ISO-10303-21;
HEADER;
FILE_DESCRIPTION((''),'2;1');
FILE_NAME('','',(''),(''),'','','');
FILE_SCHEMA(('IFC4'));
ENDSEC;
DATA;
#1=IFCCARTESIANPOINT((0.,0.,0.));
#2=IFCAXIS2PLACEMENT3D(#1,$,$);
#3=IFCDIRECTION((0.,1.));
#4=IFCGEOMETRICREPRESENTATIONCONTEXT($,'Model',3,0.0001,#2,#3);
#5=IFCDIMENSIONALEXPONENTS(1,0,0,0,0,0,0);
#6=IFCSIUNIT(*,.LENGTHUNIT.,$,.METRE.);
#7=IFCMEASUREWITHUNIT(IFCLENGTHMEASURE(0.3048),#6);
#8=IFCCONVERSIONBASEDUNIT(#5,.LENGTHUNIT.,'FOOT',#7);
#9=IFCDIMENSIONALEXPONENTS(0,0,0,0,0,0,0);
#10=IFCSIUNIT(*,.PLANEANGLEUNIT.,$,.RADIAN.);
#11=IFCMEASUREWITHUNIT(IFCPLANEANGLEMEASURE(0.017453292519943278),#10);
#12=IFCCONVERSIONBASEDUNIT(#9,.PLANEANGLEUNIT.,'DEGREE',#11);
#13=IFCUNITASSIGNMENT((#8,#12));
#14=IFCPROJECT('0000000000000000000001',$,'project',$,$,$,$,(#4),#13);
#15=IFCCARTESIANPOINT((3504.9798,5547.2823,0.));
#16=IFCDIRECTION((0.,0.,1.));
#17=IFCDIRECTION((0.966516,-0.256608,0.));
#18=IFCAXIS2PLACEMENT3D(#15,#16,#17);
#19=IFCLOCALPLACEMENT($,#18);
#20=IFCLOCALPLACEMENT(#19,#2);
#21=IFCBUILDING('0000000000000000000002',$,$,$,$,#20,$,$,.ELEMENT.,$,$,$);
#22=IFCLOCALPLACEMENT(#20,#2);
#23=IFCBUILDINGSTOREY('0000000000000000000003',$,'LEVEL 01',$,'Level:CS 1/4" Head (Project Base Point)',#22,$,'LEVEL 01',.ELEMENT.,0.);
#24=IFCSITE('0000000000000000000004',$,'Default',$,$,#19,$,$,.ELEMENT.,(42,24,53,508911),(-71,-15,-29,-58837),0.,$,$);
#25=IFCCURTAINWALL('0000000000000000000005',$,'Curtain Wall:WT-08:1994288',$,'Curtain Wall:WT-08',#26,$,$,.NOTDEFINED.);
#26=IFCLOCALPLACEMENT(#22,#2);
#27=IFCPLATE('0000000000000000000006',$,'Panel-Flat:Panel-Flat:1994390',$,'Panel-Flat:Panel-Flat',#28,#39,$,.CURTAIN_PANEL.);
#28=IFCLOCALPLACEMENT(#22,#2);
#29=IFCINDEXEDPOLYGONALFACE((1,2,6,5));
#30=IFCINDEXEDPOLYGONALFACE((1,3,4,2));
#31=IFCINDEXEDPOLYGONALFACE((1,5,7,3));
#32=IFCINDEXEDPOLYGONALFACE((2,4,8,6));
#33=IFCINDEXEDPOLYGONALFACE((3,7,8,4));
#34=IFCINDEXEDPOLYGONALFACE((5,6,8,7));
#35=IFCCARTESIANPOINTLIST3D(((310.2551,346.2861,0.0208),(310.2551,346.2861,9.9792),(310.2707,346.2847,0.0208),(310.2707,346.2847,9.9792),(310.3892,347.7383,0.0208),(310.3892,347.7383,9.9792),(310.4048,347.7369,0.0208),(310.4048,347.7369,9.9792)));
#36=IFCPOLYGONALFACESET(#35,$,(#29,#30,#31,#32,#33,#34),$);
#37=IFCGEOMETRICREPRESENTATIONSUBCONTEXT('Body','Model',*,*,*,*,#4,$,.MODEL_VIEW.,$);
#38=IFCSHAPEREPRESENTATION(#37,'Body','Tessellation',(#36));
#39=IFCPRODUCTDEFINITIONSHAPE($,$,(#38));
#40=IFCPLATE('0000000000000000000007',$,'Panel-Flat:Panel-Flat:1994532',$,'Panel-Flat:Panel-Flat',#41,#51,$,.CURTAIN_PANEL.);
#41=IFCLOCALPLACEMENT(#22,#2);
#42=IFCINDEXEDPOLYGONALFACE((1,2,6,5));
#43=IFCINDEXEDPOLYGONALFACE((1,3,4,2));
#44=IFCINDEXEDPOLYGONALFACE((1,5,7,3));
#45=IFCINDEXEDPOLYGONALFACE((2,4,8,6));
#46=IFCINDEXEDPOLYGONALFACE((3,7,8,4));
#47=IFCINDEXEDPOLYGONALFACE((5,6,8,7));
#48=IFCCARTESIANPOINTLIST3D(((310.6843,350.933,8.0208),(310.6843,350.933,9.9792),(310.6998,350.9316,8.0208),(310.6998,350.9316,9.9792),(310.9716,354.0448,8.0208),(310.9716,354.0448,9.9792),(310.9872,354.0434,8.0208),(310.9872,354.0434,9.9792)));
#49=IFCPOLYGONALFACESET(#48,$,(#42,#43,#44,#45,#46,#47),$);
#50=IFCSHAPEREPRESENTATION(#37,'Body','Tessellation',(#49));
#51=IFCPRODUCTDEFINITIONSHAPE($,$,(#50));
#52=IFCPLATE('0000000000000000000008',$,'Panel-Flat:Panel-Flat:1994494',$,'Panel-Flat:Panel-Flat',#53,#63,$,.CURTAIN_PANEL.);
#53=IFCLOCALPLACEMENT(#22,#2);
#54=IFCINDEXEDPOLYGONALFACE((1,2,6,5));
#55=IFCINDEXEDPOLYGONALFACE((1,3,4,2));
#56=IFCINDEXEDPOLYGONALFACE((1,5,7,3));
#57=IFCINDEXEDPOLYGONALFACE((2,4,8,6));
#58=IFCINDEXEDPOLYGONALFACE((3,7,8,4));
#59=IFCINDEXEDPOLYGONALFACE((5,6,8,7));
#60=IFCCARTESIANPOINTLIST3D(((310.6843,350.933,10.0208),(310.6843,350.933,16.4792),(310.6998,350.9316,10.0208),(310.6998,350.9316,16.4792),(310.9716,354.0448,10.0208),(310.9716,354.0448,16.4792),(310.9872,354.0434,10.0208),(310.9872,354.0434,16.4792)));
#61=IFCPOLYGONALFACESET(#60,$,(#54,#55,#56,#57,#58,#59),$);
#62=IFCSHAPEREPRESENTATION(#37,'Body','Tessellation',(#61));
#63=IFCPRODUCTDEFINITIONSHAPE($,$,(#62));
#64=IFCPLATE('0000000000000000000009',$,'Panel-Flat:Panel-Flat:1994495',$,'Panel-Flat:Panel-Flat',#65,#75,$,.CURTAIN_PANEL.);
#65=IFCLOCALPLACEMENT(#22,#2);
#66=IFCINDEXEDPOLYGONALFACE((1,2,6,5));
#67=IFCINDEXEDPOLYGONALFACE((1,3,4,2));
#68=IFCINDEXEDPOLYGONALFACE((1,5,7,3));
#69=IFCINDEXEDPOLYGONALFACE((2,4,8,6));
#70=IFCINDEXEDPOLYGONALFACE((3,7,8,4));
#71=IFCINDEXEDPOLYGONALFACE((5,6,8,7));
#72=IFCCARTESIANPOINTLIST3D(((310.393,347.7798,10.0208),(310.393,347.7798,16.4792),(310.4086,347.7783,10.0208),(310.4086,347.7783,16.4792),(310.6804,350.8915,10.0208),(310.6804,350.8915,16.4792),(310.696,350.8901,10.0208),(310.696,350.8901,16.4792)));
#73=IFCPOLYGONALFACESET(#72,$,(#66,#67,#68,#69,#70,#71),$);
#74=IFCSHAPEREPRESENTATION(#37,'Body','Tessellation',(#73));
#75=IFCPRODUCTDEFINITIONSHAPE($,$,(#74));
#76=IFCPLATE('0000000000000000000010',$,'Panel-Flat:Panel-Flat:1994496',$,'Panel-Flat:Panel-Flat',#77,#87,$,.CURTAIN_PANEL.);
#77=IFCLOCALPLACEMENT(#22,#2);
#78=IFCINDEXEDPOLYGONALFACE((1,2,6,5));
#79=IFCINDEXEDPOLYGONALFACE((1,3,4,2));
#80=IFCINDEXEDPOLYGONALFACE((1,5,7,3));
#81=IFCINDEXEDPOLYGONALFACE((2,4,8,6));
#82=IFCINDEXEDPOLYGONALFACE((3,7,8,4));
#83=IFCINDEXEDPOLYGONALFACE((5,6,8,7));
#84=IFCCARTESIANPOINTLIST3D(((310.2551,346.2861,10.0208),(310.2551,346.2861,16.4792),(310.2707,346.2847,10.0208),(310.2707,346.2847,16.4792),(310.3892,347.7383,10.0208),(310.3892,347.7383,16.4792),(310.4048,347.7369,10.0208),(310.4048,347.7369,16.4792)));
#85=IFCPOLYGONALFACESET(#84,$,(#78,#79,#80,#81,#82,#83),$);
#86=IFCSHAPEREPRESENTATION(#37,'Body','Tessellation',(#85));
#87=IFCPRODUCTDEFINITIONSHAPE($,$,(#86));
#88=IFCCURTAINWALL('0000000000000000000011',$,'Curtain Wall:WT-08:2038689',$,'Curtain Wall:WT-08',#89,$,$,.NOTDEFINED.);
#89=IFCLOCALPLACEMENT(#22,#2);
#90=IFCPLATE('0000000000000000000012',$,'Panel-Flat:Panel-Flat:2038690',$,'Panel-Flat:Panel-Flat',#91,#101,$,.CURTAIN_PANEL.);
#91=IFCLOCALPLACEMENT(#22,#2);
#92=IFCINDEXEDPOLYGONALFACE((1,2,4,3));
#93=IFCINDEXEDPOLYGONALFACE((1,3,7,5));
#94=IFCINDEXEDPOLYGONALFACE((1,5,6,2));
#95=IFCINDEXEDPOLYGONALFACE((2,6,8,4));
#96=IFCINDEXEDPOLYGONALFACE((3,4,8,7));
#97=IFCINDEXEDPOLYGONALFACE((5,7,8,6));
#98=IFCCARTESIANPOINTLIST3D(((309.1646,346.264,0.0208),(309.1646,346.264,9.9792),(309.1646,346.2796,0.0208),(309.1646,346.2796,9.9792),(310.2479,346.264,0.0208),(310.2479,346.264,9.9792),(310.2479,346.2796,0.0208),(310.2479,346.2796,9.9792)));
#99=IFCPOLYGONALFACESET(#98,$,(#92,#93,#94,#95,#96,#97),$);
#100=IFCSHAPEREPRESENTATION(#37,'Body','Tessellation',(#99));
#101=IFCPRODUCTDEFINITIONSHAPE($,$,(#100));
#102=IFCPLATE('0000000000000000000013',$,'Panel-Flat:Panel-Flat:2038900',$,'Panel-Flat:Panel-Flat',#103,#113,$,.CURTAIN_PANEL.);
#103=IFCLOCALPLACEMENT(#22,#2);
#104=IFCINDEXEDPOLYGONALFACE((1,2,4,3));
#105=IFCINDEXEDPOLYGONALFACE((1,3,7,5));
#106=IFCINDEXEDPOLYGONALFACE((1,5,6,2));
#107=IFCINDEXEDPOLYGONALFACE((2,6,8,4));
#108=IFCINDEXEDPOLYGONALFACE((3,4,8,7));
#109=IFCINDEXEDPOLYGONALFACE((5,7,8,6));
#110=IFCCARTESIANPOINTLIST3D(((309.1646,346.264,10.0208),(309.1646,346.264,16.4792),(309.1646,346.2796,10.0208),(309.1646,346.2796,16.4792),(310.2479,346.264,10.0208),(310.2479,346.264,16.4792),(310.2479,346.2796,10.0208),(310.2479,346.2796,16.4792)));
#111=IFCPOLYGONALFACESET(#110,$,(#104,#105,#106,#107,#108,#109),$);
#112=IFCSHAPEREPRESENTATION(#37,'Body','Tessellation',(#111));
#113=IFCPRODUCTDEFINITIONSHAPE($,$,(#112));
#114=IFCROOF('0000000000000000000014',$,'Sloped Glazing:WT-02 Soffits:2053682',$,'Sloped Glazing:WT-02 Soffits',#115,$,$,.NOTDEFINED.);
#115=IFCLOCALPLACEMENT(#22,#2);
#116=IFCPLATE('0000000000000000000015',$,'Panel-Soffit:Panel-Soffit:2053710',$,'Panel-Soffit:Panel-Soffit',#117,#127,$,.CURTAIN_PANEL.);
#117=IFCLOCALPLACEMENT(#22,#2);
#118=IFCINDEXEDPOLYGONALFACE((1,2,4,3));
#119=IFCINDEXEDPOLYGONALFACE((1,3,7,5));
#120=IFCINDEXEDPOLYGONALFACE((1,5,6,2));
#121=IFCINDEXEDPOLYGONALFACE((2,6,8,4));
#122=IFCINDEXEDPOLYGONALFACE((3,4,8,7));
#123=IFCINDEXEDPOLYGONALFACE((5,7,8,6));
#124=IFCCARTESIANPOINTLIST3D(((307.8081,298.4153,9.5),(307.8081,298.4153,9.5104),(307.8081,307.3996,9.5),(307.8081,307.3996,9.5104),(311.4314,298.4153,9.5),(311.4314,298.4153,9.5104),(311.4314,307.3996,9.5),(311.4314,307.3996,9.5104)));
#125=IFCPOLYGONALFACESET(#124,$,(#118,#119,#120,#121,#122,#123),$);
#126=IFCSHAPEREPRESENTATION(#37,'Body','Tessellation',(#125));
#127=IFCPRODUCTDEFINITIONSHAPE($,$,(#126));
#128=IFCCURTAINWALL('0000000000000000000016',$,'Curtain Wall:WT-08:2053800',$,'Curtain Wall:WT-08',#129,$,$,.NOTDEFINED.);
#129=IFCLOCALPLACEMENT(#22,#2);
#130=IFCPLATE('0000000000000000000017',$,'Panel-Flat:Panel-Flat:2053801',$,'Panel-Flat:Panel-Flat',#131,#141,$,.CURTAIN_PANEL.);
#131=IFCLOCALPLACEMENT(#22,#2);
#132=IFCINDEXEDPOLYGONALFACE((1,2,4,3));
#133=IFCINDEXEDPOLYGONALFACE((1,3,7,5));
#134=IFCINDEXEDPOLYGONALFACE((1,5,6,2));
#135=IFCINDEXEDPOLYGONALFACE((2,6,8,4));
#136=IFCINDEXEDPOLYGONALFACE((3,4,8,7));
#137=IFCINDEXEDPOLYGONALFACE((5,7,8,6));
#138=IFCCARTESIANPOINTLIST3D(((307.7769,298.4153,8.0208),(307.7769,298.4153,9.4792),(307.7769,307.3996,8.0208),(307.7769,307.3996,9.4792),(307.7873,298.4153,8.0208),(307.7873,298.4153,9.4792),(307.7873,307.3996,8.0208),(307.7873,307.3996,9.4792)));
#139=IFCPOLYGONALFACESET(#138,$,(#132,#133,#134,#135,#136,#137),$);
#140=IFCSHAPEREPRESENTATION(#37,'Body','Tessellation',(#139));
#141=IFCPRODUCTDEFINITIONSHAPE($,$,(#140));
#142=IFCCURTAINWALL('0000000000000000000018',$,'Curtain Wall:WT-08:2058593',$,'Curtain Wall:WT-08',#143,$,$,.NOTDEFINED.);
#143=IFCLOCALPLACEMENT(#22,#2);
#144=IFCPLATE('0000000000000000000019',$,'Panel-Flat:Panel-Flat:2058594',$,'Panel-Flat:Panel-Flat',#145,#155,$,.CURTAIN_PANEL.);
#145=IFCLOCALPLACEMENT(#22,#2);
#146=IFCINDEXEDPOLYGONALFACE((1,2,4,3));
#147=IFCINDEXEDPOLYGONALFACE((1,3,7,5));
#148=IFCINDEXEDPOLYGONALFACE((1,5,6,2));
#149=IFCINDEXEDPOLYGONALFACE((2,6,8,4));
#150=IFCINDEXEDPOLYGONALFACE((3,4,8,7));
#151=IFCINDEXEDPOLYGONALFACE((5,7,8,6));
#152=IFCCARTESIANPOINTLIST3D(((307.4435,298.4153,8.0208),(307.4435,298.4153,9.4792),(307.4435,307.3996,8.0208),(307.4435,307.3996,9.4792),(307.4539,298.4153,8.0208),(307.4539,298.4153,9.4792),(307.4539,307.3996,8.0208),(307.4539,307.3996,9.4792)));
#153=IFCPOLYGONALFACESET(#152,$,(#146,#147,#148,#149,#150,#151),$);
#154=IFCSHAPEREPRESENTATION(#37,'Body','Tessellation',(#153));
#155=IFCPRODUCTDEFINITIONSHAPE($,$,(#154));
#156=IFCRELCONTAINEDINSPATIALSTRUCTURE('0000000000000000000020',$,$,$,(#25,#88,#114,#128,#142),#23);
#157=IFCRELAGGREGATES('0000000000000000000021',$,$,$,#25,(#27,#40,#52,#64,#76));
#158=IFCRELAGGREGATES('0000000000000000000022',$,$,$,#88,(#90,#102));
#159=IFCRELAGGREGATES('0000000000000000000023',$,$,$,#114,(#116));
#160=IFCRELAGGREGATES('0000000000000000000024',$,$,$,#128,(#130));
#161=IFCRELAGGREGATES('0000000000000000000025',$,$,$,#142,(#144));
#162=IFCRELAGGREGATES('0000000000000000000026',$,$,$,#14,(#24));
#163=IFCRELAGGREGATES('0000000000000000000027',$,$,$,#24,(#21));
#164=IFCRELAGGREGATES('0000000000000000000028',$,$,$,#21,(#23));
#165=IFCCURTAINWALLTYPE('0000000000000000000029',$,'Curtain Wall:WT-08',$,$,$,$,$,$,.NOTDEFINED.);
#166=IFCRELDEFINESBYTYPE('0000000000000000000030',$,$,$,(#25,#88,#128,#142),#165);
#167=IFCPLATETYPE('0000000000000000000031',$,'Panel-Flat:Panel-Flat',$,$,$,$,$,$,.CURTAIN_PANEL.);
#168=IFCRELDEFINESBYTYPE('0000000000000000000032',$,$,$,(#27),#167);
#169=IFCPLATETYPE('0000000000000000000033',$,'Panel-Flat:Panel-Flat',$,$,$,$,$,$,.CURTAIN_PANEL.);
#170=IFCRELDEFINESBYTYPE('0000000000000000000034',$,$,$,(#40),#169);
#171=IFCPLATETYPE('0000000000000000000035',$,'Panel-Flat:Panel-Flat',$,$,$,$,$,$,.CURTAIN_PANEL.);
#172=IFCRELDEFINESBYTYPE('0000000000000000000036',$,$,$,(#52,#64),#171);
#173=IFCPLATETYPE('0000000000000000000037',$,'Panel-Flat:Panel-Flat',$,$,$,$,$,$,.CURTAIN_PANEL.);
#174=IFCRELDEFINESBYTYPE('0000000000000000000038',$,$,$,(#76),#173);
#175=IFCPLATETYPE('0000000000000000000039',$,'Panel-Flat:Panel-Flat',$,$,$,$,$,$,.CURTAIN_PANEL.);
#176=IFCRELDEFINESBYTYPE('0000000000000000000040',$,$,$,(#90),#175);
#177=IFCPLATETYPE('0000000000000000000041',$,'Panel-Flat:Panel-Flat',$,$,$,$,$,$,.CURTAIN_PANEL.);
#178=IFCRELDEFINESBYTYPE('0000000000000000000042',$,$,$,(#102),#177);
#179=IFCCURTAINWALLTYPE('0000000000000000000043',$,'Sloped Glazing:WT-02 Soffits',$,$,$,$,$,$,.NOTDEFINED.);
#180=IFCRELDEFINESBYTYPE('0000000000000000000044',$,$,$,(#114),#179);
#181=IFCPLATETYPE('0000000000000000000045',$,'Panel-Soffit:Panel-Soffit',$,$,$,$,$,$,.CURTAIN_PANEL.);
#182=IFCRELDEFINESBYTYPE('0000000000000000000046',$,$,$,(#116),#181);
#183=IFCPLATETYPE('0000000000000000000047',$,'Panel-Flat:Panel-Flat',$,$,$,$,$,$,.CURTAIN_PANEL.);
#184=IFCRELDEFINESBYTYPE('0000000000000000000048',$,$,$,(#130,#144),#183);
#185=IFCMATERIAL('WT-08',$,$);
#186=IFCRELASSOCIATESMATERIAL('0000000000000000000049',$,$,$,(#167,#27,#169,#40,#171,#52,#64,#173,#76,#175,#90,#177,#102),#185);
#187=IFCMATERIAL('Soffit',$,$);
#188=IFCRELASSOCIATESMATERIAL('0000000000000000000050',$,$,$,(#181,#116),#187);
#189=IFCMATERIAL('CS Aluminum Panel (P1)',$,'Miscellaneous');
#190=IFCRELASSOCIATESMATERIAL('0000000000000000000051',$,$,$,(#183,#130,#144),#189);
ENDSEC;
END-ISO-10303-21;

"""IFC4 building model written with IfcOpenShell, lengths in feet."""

from ifc_helpers import new_model, entity, si_unit, converted_unit, direction, frame, origin, place, context, subcontext, project, spatial, indexed_curve, outline, extrude, source, transform, mapped, material, type_object, type_shapes, element, aggregate, save


model = new_model("IFC4")

# Units and contexts
model_context = context("Model", 3, precision=0.0001, world=origin(), true_north=direction((0.0, 1.0)))
body_context = subcontext(model_context, "Body", "Model", "MODEL_VIEW")
ifc_project = project(units=[converted_unit("LENGTHUNIT", "FOOT", entity("IfcLengthMeasure", 0.3048), si_unit("LENGTHUNIT", "METRE"), dimensions=[1, 0, 0, 0, 0, 0, 0]), converted_unit("PLANEANGLEUNIT", "DEGREE", entity("IfcPlaneAngleMeasure", 0.017453292519943278), si_unit("PLANEANGLEUNIT", "RADIAN"), dimensions=[0, 0, 0, 0, 0, 0, 0])], contexts=[model_context])

# Site, building, storey
site_placement = place(None, frame((3504.9798, 5547.2823, 0.0), z_axis=(0.0, 0.0, 1.0), x_axis=(0.966516, -0.256608, 0.0)))
site = spatial("IfcSite", under=ifc_project, at=site_placement, Name="Default", CompositionType="ELEMENT", RefLatitude=(42, 24, 53, 508911), RefLongitude=(-71, -15, -29, -58837), RefElevation=0.0)
building_placement = place(site_placement, origin())
building = spatial("IfcBuilding", under=site, at=building_placement, CompositionType="ELEMENT")
storey_placement = place(building_placement, origin())
storey = spatial("IfcBuildingStorey", under=building, at=storey_placement, Name="LEVEL 01", ObjectType="Level:CS 1/4\" Head (Project Base Point)", LongName="LEVEL 01", CompositionType="ELEMENT", Elevation=0.0)

# Shared definitions
curtain_wall_type_1 = type_object("IfcCurtainWallType", Name="Curtain Wall:WT-08", PredefinedType="NOTDEFINED")
ifc_material_1 = material(Name="WT-08")

# Curtain wall
curtain_wall_1_placement = place(storey_placement, origin())
curtain_wall_1 = element("IfcCurtainWall", 1, at=curtain_wall_1_placement, inside=storey, type_object=curtain_wall_type_1, Name="Curtain Wall:WT-08:1994288", ObjectType="Curtain Wall:WT-08", PredefinedType="NOTDEFINED")

# Plates
plate_type_1 = type_object("IfcPlateType", Name="Panel-Flat:Panel-Flat", PredefinedType="CURTAIN_PANEL", material=ifc_material_1)
shared_shape_1 = source(origin(), body_context, "Body", "SweptSolid", [
    extrude(outline(indexed_curve([(-0.0078, -0.7292), (0.0078, -0.7292), (0.0078, 0.7292), (-0.0078, 0.7292), (-0.0078, -0.7292)], self_intersect=False)), frame((0.0, -0.0078, 0.0208), z_axis=(0.0, 0.0, 1.0), x_axis=(0.0, -1.0, 0.0)), (0.0, 0.0, 1.0), 9.9583),
])
type_shapes(plate_type_1, [shared_shape_1])
plate_1_placement = place(curtain_wall_1_placement, frame((310.3377, 347.0108, 0.0), z_axis=(0.0, 0.0, 1.0), x_axis=(-0.091962, -0.995763, 0.0)))
plate_1 = element("IfcPlate", 2, at=plate_1_placement, type_object=plate_type_1, material=ifc_material_1, Name="Panel-Flat:Panel-Flat:1994390", ObjectType="Panel-Flat:Panel-Flat", PredefinedType="CURTAIN_PANEL", context=body_context, shape_type="MappedRepresentation", body=[
    mapped(shared_shape_1, transform((0.0, 0.0, 0.0), scale=1.0)),
])
plate_type_2 = type_object("IfcPlateType", Name="Panel-Flat:Panel-Flat", PredefinedType="CURTAIN_PANEL", material=ifc_material_1)
shared_shape_2 = source(origin(), body_context, "Body", "SweptSolid", [
    extrude(outline(indexed_curve([(-0.0078, -1.5625), (0.0078, -1.5625), (0.0078, 1.5625), (-0.0078, 1.5625), (-0.0078, -1.5625)], self_intersect=False)), frame((0.0, -0.0078, 0.0208), z_axis=(0.0, 0.0, 1.0), x_axis=(0.0, -1.0, 0.0)), (0.0, 0.0, 1.0), 1.9583),
])
type_shapes(plate_type_2, [shared_shape_2])
plate_2_placement = place(curtain_wall_1_placement, frame((310.8435, 352.4875, 8.0), z_axis=(0.0, 0.0, 1.0), x_axis=(-0.091962, -0.995763, 0.0)))
plate_2 = element("IfcPlate", 3, at=plate_2_placement, type_object=plate_type_2, material=ifc_material_1, Name="Panel-Flat:Panel-Flat:1994532", ObjectType="Panel-Flat:Panel-Flat", PredefinedType="CURTAIN_PANEL", context=body_context, shape_type="MappedRepresentation", body=[
    mapped(shared_shape_2, transform((0.0, 0.0, 0.0), scale=1.0)),
])
plate_type_3 = type_object("IfcPlateType", Name="Panel-Flat:Panel-Flat", PredefinedType="CURTAIN_PANEL", material=ifc_material_1)
shared_shape_3 = source(origin(), body_context, "Body", "SweptSolid", [
    extrude(outline(indexed_curve([(-0.0078, -1.5625), (0.0078, -1.5625), (0.0078, 1.5625), (-0.0078, 1.5625), (-0.0078, -1.5625)], self_intersect=False)), frame((0.0, -0.0078, 0.0208), z_axis=(0.0, 0.0, 1.0), x_axis=(0.0, -1.0, 0.0)), (0.0, 0.0, 1.0), 6.4583),
])
type_shapes(plate_type_3, [shared_shape_3])
plate_3_placement = place(curtain_wall_1_placement, frame((310.8435, 352.4875, 10.0), z_axis=(0.0, 0.0, 1.0), x_axis=(-0.091962, -0.995763, 0.0)))
plate_3 = element("IfcPlate", 4, at=plate_3_placement, type_object=plate_type_3, material=ifc_material_1, Name="Panel-Flat:Panel-Flat:1994494", ObjectType="Panel-Flat:Panel-Flat", PredefinedType="CURTAIN_PANEL", context=body_context, shape_type="MappedRepresentation", body=[
    mapped(shared_shape_3, transform((0.0, 0.0, 0.0), scale=1.0)),
])
plate_4_placement = place(curtain_wall_1_placement, frame((310.5523, 349.3342, 10.0), z_axis=(0.0, 0.0, 1.0), x_axis=(-0.091962, -0.995763, 0.0)))
plate_4 = element("IfcPlate", 5, at=plate_4_placement, type_object=plate_type_3, material=ifc_material_1, Name="Panel-Flat:Panel-Flat:1994495", ObjectType="Panel-Flat:Panel-Flat", PredefinedType="CURTAIN_PANEL", context=body_context, shape_type="MappedRepresentation", body=[
    mapped(shared_shape_3, transform((0.0, 0.0, 0.0), scale=1.0)),
])
plate_type_4 = type_object("IfcPlateType", Name="Panel-Flat:Panel-Flat", PredefinedType="CURTAIN_PANEL", material=ifc_material_1)
shared_shape_4 = source(origin(), body_context, "Body", "SweptSolid", [
    extrude(outline(indexed_curve([(-0.0078, -0.7292), (0.0078, -0.7292), (0.0078, 0.7292), (-0.0078, 0.7292), (-0.0078, -0.7292)], self_intersect=False)), frame((0.0, -0.0078, 0.0208), z_axis=(0.0, 0.0, 1.0), x_axis=(0.0, -1.0, 0.0)), (0.0, 0.0, 1.0), 6.4583),
])
type_shapes(plate_type_4, [shared_shape_4])
plate_5_placement = place(curtain_wall_1_placement, frame((310.3377, 347.0108, 10.0), z_axis=(0.0, 0.0, 1.0), x_axis=(-0.091962, -0.995763, 0.0)))
plate_5 = element("IfcPlate", 6, at=plate_5_placement, type_object=plate_type_4, material=ifc_material_1, Name="Panel-Flat:Panel-Flat:1994496", ObjectType="Panel-Flat:Panel-Flat", PredefinedType="CURTAIN_PANEL", context=body_context, shape_type="MappedRepresentation", body=[
    mapped(shared_shape_4, transform((0.0, 0.0, 0.0), scale=1.0)),
])
aggregate(curtain_wall_1, [plate_1, plate_2, plate_3, plate_4, plate_5])

# Curtain wall, plates
curtain_wall_2_placement = place(storey_placement, origin())
curtain_wall_2 = element("IfcCurtainWall", 7, at=curtain_wall_2_placement, inside=storey, type_object=curtain_wall_type_1, Name="Curtain Wall:WT-08:2038689", ObjectType="Curtain Wall:WT-08", PredefinedType="NOTDEFINED")
plate_type_5 = type_object("IfcPlateType", Name="Panel-Flat:Panel-Flat", PredefinedType="CURTAIN_PANEL", material=ifc_material_1)
shared_shape_5 = source(origin(), body_context, "Body", "SweptSolid", [
    extrude(outline(indexed_curve([(-0.0078, -0.5417), (0.0078, -0.5417), (0.0078, 0.5417), (-0.0078, 0.5417), (-0.0078, -0.5417)], self_intersect=False)), frame((0.0, -0.0078, 0.0208), z_axis=(0.0, 0.0, 1.0), x_axis=(0.0, -1.0, 0.0)), (0.0, 0.0, 1.0), 9.9583),
])
type_shapes(plate_type_5, [shared_shape_5])
plate_6_placement = place(curtain_wall_2_placement, frame((309.7062, 346.264, 0.0), z_axis=(0.0, 0.0, 1.0), x_axis=(-1.0, 0.0, 0.0)))
plate_6 = element("IfcPlate", 8, at=plate_6_placement, type_object=plate_type_5, material=ifc_material_1, Name="Panel-Flat:Panel-Flat:2038690", ObjectType="Panel-Flat:Panel-Flat", PredefinedType="CURTAIN_PANEL", context=body_context, shape_type="MappedRepresentation", body=[
    mapped(shared_shape_5, transform((0.0, 0.0, 0.0), scale=1.0)),
])
plate_type_6 = type_object("IfcPlateType", Name="Panel-Flat:Panel-Flat", PredefinedType="CURTAIN_PANEL", material=ifc_material_1)
shared_shape_6 = source(origin(), body_context, "Body", "SweptSolid", [
    extrude(outline(indexed_curve([(-0.0078, -0.5417), (0.0078, -0.5417), (0.0078, 0.5417), (-0.0078, 0.5417), (-0.0078, -0.5417)], self_intersect=False)), frame((0.0, -0.0078, 0.0208), z_axis=(0.0, 0.0, 1.0), x_axis=(0.0, -1.0, 0.0)), (0.0, 0.0, 1.0), 6.4583),
])
type_shapes(plate_type_6, [shared_shape_6])
plate_7_placement = place(curtain_wall_2_placement, frame((309.7062, 346.264, 10.0), z_axis=(0.0, 0.0, 1.0), x_axis=(-1.0, 0.0, 0.0)))
plate_7 = element("IfcPlate", 9, at=plate_7_placement, type_object=plate_type_6, material=ifc_material_1, Name="Panel-Flat:Panel-Flat:2038900", ObjectType="Panel-Flat:Panel-Flat", PredefinedType="CURTAIN_PANEL", context=body_context, shape_type="MappedRepresentation", body=[
    mapped(shared_shape_6, transform((0.0, 0.0, 0.0), scale=1.0)),
])
aggregate(curtain_wall_2, [plate_6, plate_7])

# Roof, plate
curtain_wall_type_2 = type_object("IfcCurtainWallType", Name="Sloped Glazing:WT-02 Soffits", PredefinedType="NOTDEFINED")
roof_placement = place(storey_placement, origin())
roof = element("IfcRoof", 10, at=roof_placement, inside=storey, type_object=curtain_wall_type_2, Name="Sloped Glazing:WT-02 Soffits:2053682", ObjectType="Sloped Glazing:WT-02 Soffits", PredefinedType="NOTDEFINED")
ifc_material_2 = material(Name="Soffit")
plate_type_7 = type_object("IfcPlateType", Name="Panel-Soffit:Panel-Soffit", PredefinedType="CURTAIN_PANEL", material=ifc_material_2)
shared_shape_7 = source(origin(), body_context, "Body", "SweptSolid", [
    extrude(outline(indexed_curve([(-0.0052, -1.8117), (0.0052, -1.8117), (0.0052, 1.8117), (-0.0052, 1.8117), (-0.0052, -1.8117)], self_intersect=False)), frame((0.0, -0.0052, 0.0208), z_axis=(0.0, 0.0, 1.0), x_axis=(0.0, -1.0, 0.0)), (0.0, 0.0, 1.0), 8.9844),
])
type_shapes(plate_type_7, [shared_shape_7])
plate_8_placement = place(roof_placement, frame((309.6198, 298.3944, 9.5), z_axis=(0.0, 1.0, 0.0), x_axis=(1.0, 0.0, 0.0)))
plate_8 = element("IfcPlate", 11, at=plate_8_placement, type_object=plate_type_7, material=ifc_material_2, Name="Panel-Soffit:Panel-Soffit:2053710", ObjectType="Panel-Soffit:Panel-Soffit", PredefinedType="CURTAIN_PANEL", context=body_context, shape_type="MappedRepresentation", body=[
    mapped(shared_shape_7, transform((0.0, 0.0, 0.0), scale=1.0)),
])
aggregate(roof, [plate_8])

# Curtain walls, plates
curtain_wall_3_placement = place(storey_placement, origin())
curtain_wall_3 = element("IfcCurtainWall", 12, at=curtain_wall_3_placement, inside=storey, type_object=curtain_wall_type_1, Name="Curtain Wall:WT-08:2053800", ObjectType="Curtain Wall:WT-08", PredefinedType="NOTDEFINED")
ifc_material_3 = material(Name="CS Aluminum Panel (P1)", Category="Miscellaneous")
plate_type_8 = type_object("IfcPlateType", Name="Panel-Flat:Panel-Flat", PredefinedType="CURTAIN_PANEL", material=ifc_material_3)
shared_shape_8 = source(origin(), body_context, "Body", "SweptSolid", [
    extrude(outline(indexed_curve([(-0.0052, -4.4922), (0.0052, -4.4922), (0.0052, 4.4922), (-0.0052, 4.4922), (-0.0052, -4.4922)], self_intersect=False)), frame((0.0, -0.0052, 0.0208), z_axis=(0.0, 0.0, 1.0), x_axis=(0.0, -1.0, 0.0)), (0.0, 0.0, 1.0), 1.4583),
])
type_shapes(plate_type_8, [shared_shape_8])
plate_9_placement = place(curtain_wall_3_placement, frame((307.7873, 302.9075, 8.0), z_axis=(0.0, 0.0, 1.0), x_axis=(0.0, -1.0, 0.0)))
plate_9 = element("IfcPlate", 13, at=plate_9_placement, type_object=plate_type_8, material=ifc_material_3, Name="Panel-Flat:Panel-Flat:2053801", ObjectType="Panel-Flat:Panel-Flat", PredefinedType="CURTAIN_PANEL", context=body_context, shape_type="MappedRepresentation", body=[
    mapped(shared_shape_8, transform((0.0, 0.0, 0.0), scale=1.0)),
])
aggregate(curtain_wall_3, [plate_9])
curtain_wall_4_placement = place(storey_placement, origin())
curtain_wall_4 = element("IfcCurtainWall", 14, at=curtain_wall_4_placement, inside=storey, type_object=curtain_wall_type_1, Name="Curtain Wall:WT-08:2058593", ObjectType="Curtain Wall:WT-08", PredefinedType="NOTDEFINED")
plate_10_placement = place(curtain_wall_4_placement, frame((307.4539, 302.9075, 8.0), z_axis=(0.0, 0.0, 1.0), x_axis=(0.0, -1.0, 0.0)))
plate_10 = element("IfcPlate", 15, at=plate_10_placement, type_object=plate_type_8, material=ifc_material_3, Name="Panel-Flat:Panel-Flat:2058594", ObjectType="Panel-Flat:Panel-Flat", PredefinedType="CURTAIN_PANEL", context=body_context, shape_type="MappedRepresentation", body=[
    mapped(shared_shape_8, transform((0.0, 0.0, 0.0), scale=1.0)),
])
aggregate(curtain_wall_4, [plate_10])

save(model, "model.ifc")
